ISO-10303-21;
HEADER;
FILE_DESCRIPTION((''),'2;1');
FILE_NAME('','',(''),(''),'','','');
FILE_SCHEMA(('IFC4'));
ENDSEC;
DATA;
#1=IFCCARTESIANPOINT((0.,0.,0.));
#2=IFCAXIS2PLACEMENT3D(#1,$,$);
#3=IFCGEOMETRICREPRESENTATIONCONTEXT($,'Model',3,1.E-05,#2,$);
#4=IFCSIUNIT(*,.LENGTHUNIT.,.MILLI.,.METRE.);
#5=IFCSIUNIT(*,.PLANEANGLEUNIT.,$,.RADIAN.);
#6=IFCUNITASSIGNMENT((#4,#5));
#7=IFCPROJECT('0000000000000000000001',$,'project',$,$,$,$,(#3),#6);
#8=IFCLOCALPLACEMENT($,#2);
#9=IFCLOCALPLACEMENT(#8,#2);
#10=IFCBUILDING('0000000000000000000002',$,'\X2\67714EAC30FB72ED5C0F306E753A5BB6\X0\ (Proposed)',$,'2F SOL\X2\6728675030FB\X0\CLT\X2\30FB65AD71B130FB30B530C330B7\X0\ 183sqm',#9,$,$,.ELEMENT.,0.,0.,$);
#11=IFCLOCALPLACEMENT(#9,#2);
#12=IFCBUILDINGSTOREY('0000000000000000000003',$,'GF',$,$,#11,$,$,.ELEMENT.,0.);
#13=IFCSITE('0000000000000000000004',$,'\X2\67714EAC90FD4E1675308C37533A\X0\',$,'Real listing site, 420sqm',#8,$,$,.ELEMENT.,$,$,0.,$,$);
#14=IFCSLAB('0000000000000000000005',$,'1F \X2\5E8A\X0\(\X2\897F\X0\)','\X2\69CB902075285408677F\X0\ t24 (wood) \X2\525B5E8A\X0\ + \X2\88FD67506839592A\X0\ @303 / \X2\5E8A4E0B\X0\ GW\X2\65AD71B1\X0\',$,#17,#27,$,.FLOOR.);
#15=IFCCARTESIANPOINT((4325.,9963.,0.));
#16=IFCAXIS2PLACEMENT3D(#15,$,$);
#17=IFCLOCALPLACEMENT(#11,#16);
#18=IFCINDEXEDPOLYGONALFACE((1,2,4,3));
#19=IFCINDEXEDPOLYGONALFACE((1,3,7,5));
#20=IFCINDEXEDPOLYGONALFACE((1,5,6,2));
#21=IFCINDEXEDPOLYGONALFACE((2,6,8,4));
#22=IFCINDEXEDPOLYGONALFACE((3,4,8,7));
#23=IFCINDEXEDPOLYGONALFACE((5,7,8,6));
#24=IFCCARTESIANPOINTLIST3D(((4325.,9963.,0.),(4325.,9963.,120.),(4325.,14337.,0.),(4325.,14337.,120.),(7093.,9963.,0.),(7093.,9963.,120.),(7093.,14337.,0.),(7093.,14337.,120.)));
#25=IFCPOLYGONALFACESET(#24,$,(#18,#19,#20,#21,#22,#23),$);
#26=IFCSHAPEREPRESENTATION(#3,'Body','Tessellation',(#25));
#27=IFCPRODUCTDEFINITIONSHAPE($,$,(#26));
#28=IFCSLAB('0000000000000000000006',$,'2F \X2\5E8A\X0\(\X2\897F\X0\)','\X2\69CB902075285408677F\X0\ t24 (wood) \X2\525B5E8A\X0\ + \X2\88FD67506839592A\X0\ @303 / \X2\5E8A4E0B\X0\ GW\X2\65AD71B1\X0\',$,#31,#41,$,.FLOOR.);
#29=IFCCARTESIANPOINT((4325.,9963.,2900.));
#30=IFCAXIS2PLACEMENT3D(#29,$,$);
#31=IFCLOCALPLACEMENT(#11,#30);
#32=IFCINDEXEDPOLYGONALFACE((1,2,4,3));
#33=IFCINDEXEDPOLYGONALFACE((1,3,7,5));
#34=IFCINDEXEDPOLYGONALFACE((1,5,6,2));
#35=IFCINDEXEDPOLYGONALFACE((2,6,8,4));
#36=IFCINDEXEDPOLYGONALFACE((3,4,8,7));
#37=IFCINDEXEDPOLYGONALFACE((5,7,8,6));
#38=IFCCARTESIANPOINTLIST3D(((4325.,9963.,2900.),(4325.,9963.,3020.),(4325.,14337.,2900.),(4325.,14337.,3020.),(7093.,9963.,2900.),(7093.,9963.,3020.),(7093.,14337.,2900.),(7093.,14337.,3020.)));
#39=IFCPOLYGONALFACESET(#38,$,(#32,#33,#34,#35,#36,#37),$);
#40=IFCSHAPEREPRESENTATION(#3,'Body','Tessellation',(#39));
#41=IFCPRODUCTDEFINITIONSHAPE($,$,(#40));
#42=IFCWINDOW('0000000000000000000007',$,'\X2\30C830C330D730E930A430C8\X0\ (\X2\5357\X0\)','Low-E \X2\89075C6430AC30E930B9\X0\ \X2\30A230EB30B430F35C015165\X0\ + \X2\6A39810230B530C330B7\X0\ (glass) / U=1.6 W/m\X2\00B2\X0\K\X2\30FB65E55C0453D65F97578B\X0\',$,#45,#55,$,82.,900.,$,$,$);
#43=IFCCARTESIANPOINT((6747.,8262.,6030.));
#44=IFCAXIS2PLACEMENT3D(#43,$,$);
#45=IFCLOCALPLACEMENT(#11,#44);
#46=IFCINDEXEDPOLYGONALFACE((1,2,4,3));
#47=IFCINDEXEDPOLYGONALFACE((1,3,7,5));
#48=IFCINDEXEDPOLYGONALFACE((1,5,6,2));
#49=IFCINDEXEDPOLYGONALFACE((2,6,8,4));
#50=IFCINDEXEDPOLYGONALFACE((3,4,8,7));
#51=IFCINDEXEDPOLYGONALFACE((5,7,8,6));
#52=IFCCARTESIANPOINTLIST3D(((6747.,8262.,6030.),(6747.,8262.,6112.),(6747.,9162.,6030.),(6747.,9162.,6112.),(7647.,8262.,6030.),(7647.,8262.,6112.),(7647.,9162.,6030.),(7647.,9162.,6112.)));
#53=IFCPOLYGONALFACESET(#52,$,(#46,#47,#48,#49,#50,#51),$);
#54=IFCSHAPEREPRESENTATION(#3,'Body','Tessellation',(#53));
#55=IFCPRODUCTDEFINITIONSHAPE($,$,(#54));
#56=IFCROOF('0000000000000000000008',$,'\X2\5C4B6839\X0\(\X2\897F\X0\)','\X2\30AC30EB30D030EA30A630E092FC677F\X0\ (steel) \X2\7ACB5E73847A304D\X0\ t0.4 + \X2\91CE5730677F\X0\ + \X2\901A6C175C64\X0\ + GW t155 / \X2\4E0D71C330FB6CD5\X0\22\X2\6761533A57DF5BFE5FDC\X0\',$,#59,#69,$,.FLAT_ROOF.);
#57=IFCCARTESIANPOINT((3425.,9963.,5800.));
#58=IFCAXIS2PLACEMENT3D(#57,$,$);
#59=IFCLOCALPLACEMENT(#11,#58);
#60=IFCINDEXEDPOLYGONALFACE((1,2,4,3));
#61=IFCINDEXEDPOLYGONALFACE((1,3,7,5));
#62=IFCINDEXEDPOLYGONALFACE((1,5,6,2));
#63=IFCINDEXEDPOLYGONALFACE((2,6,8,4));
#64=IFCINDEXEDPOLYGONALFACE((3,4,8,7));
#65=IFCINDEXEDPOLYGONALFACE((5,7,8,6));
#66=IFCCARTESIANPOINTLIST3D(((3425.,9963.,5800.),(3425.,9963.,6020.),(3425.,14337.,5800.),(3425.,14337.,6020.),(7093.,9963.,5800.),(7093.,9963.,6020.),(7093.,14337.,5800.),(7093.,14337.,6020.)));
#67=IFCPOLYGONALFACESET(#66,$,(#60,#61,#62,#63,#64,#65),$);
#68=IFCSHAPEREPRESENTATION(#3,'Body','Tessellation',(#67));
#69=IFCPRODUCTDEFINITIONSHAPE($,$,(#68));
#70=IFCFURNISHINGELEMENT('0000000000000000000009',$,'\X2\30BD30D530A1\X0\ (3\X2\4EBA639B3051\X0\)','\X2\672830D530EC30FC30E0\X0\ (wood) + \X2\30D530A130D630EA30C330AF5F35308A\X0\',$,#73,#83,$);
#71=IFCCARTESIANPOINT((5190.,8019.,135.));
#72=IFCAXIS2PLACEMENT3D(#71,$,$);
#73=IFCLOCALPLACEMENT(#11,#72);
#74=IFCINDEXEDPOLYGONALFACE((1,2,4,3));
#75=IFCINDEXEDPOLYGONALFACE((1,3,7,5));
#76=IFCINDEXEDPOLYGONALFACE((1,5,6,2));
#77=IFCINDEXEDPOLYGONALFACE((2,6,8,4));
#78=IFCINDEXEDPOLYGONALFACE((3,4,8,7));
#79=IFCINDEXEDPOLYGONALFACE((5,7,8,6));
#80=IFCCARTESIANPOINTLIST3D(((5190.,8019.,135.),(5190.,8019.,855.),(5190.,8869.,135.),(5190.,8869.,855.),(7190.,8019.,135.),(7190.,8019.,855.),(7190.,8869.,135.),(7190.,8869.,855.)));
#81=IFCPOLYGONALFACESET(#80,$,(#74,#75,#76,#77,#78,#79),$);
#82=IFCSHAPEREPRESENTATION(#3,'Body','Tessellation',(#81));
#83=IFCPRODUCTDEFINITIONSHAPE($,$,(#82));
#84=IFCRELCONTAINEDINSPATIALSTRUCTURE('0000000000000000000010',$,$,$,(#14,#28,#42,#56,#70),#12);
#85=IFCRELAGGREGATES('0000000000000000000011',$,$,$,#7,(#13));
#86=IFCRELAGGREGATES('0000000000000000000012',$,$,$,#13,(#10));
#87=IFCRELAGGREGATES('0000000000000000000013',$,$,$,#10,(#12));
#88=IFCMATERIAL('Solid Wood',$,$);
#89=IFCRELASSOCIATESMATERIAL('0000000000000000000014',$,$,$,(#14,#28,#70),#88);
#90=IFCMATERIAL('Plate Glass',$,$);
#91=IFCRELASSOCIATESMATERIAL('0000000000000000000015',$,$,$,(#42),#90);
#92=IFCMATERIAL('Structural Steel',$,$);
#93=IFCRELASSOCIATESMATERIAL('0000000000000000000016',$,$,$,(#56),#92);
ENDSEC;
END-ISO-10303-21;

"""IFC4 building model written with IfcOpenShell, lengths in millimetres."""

from ifc_helpers import new_model, si_unit, frame, frame_2d, origin, place, context, project, spatial, rectangle, extrude, material, element, save


model = new_model("IFC4")

# Units and contexts
model_context = context("Model", 3, precision=1e-05, world=origin())
ifc_project = project(units=[si_unit("LENGTHUNIT", "METRE", prefix="MILLI"), si_unit("PLANEANGLEUNIT", "RADIAN")], contexts=[model_context])

# Site, building, storey
site_placement = place(None, origin())
site = spatial("IfcSite", under=ifc_project, at=site_placement, Name="東京都世田谷区", ObjectType="Real listing site, 420sqm", CompositionType="ELEMENT", RefElevation=0.0)
building_placement = place(site_placement, origin())
building = spatial("IfcBuilding", under=site, at=building_placement, Name="東京・狭小の町家 (Proposed)", ObjectType="2F SOL木材・CLT・断熱・サッシ 183sqm", CompositionType="ELEMENT", ElevationOfRefHeight=0.0, ElevationOfTerrain=0.0)
storey_placement = place(building_placement, origin())
storey = spatial("IfcBuildingStorey", under=building, at=storey_placement, Name="GF", CompositionType="ELEMENT", Elevation=0.0)

# Shared definitions
ifc_material_1 = material(Name="Solid Wood")

# Slabs
slab_1_placement = place(storey_placement, frame((4325.0, 9963.0, 0.0)))
element("IfcSlab", 1, at=slab_1_placement, inside=storey, material=ifc_material_1, Name="1F 床(西)", Description="構造用合板 t24 (wood) 剛床 + 製材根太 @303 / 床下 GW断熱", PredefinedType="FLOOR", context=model_context, shape_type="SweptSolid", body=[
    extrude(rectangle(XDim=2768.0, YDim=4374.0, at=frame_2d((1384.0, 2187.0))), frame((4325.0, 9963.0, 0.0)), (0.0, 0.0, 1.0), 120.0),
])
slab_2_placement = place(storey_placement, frame((4325.0, 9963.0, 2900.0)))
element("IfcSlab", 2, at=slab_2_placement, inside=storey, material=ifc_material_1, Name="2F 床(西)", Description="構造用合板 t24 (wood) 剛床 + 製材根太 @303 / 床下 GW断熱", PredefinedType="FLOOR", context=model_context, shape_type="SweptSolid", body=[
    extrude(rectangle(XDim=2768.0, YDim=4374.0, at=frame_2d((1384.0, 2187.0))), frame((4325.0, 9963.0, 2900.0)), (0.0, 0.0, 1.0), 120.0),
])

# Window
ifc_material_2 = material(Name="Plate Glass")
window_placement = place(storey_placement, frame((6747.0, 8262.0, 6030.0)))
element("IfcWindow", 3, at=window_placement, inside=storey, material=ifc_material_2, Name="トップライト (南)", Description="Low-E 複層ガラス アルゴン封入 + 樹脂サッシ (glass) / U=1.6 W/m²K・日射取得型", OverallHeight=82.0, OverallWidth=900.0, context=model_context, shape_type="SweptSolid", body=[
    extrude(rectangle(XDim=900.0, YDim=900.0, at=frame_2d((450.0, 450.0))), frame((6747.0, 8262.0, 6030.0)), (0.0, 0.0, 1.0), 82.0),
])

# Roof
ifc_material_3 = material(Name="Structural Steel")
for number, where, name in (
    (4, (3425.0, 9963.0, 5800.0), "屋根(西)"),
):
    element("IfcRoof", number, at=place(storey_placement, frame(where)), inside=storey, material=ifc_material_3, Name=name, Description="ガルバリウム鋼板 (steel) 立平葺き t0.4 + 野地板 + 通気層 + GW t155 / 不燃・法22条区域対応", PredefinedType="FLAT_ROOF", context=model_context, shape_type="SweptSolid", body=[
        extrude(rectangle(XDim=3668.0, YDim=4374.0, at=frame_2d((1834.0, 2187.0))), frame((3425.0, 9963.0, 5800.0)), (0.0, 0.0, 1.0), 220.0),
    ])

# Furnishing element
furnishing_placement = place(storey_placement, frame((5190.0, 8019.0, 135.0)))
element("IfcFurnishingElement", 5, at=furnishing_placement, inside=storey, material=ifc_material_1, Name="ソファ (3人掛け)", Description="木フレーム (wood) + ファブリック張り", context=model_context, shape_type="SweptSolid", body=[
    extrude(rectangle(XDim=2000.0, YDim=850.0, at=frame_2d((1000.0, 425.0))), frame((5190.0, 8019.0, 135.0)), (0.0, 0.0, 1.0), 720.0),
])

save(model, "model.ifc")
